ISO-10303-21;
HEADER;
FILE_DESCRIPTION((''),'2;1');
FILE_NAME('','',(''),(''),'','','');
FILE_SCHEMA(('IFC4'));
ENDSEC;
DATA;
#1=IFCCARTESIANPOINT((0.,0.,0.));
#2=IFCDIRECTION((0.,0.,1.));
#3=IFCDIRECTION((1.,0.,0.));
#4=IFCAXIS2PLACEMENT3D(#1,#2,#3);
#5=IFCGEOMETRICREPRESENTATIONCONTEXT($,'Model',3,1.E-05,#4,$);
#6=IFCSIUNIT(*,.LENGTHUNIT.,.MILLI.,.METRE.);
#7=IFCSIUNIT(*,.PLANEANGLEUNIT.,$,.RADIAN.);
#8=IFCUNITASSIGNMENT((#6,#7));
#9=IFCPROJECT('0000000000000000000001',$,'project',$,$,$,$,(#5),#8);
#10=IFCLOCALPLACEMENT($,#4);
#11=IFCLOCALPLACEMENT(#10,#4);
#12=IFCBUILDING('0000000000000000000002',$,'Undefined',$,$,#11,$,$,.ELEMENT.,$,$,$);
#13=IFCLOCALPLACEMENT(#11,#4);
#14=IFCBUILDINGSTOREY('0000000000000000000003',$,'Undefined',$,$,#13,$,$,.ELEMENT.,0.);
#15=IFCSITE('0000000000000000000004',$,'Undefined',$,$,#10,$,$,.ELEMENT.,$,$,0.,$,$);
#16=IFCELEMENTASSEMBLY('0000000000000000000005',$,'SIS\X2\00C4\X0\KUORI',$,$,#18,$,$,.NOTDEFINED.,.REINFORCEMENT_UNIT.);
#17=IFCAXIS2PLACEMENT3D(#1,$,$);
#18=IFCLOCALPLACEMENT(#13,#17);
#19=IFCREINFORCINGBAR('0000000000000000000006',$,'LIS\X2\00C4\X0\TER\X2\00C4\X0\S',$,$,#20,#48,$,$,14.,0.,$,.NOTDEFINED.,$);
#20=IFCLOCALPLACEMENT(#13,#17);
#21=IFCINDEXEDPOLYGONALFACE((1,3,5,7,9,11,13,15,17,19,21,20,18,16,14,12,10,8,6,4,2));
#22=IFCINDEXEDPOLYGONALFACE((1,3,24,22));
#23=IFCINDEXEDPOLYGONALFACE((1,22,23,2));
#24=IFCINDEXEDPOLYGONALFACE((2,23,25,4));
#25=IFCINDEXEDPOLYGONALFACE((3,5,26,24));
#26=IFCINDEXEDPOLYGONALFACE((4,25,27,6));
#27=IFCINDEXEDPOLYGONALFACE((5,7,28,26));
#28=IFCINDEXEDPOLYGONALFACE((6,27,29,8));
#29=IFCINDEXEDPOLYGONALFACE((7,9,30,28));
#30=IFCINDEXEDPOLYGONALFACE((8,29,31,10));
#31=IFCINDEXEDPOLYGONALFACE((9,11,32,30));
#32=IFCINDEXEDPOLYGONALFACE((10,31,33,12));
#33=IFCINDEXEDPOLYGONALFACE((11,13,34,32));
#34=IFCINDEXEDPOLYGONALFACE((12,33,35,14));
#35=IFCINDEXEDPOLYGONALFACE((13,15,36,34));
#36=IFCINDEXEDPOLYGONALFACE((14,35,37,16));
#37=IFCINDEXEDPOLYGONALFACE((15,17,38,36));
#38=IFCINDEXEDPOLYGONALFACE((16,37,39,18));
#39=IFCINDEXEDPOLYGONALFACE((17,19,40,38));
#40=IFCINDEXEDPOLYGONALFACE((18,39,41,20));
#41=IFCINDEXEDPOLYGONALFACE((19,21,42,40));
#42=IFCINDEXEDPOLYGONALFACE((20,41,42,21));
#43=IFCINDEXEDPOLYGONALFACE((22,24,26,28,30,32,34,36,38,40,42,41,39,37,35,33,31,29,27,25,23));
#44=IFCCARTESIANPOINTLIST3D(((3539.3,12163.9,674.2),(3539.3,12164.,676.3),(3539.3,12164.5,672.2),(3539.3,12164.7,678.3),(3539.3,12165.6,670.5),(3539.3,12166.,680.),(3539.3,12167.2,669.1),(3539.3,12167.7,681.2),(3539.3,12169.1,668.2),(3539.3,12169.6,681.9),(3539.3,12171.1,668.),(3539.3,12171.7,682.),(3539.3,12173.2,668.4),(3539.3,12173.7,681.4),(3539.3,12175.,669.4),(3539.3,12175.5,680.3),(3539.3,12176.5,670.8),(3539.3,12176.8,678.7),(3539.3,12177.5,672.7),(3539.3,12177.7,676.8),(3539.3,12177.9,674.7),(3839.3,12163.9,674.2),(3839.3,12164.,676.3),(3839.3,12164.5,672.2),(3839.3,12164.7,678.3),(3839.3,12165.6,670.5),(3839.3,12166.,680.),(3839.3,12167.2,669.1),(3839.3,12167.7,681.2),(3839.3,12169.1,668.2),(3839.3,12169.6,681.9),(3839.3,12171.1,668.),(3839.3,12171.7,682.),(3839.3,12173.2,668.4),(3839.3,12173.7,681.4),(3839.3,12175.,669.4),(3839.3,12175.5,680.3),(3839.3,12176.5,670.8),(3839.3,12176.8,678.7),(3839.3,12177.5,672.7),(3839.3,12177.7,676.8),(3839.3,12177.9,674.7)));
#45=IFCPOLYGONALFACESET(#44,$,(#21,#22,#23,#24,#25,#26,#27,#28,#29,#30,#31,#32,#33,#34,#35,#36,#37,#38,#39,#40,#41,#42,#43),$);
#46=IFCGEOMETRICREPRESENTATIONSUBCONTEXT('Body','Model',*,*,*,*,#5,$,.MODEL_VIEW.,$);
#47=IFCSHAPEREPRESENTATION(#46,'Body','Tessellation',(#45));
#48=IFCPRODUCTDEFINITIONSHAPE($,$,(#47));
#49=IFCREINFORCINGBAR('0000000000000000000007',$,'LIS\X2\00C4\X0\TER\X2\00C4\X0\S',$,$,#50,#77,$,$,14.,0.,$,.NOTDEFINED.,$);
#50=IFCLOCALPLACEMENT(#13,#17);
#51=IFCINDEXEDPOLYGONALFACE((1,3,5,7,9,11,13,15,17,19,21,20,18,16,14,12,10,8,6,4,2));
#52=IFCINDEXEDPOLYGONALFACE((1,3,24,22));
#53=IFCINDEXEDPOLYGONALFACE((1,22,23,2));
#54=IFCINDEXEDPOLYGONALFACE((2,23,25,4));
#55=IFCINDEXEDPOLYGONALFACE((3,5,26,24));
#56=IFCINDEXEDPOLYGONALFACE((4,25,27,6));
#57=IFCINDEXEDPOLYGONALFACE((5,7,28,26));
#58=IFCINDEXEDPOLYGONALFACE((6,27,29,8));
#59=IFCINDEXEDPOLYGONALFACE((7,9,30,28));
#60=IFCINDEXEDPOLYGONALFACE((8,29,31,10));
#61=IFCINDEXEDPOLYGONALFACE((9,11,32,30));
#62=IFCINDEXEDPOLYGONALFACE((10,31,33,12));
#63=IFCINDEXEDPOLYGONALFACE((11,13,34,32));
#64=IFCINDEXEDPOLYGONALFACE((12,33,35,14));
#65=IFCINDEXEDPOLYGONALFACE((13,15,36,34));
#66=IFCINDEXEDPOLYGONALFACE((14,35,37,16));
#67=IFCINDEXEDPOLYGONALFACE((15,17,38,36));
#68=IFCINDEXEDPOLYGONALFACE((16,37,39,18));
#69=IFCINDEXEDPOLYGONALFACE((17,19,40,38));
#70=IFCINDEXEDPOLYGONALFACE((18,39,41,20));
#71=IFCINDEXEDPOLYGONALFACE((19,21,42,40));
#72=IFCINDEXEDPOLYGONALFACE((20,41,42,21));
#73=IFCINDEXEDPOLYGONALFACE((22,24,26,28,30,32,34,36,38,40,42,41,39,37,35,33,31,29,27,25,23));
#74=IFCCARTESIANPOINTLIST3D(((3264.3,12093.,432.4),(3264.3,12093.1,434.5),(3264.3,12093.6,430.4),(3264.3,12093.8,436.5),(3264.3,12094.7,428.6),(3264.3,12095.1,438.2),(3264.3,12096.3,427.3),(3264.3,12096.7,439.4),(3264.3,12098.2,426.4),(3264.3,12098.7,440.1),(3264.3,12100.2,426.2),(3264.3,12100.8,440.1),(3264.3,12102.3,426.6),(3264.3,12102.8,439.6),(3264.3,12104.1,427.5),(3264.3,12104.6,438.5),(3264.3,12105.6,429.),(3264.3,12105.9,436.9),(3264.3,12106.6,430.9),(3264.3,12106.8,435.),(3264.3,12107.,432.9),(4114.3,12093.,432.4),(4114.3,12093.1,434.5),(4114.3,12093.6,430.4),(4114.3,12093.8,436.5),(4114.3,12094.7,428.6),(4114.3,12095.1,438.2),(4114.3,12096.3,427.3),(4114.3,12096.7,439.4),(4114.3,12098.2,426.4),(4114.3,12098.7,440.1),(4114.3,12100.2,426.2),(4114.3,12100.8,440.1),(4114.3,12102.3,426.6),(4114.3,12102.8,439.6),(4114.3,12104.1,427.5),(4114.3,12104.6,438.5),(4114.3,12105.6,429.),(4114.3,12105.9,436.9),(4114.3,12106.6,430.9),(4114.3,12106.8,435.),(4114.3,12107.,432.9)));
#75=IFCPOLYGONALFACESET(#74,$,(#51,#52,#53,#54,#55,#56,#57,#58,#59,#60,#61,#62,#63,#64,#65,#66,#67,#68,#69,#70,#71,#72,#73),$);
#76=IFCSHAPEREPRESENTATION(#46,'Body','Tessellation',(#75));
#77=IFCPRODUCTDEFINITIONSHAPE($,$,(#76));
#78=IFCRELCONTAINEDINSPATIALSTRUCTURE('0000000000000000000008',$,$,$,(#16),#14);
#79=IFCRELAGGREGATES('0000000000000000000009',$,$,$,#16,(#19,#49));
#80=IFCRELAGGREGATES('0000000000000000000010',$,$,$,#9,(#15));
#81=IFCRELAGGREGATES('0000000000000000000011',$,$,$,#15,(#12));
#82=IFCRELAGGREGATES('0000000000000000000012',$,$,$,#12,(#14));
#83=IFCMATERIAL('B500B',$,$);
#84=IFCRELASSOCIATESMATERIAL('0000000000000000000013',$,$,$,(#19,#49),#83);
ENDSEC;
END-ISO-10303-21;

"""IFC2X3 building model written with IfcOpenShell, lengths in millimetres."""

from ifc_helpers import new_model, entity, si_unit, frame, origin_with_axes, place, context, subcontext, project, spatial, source, transform, mapped, material, element, aggregate, save


model = new_model("IFC2X3")

# Units and contexts
model_context = context("Model", 3, precision=1e-05, world=origin_with_axes())
body_context = subcontext(model_context, "Body", "Model", "MODEL_VIEW")
ifc_project = project(units=[si_unit("LENGTHUNIT", "METRE", prefix="MILLI"), si_unit("PLANEANGLEUNIT", "RADIAN")], contexts=[model_context])

# Site, building, storey
site_placement = place(None, origin_with_axes())
site = spatial("IfcSite", under=ifc_project, at=site_placement, Name="Undefined", CompositionType="ELEMENT", RefElevation=0.0)
building_placement = place(site_placement, origin_with_axes())
building = spatial("IfcBuilding", under=site, at=building_placement, Name="Undefined", CompositionType="ELEMENT")
storey_placement = place(building_placement, origin_with_axes())
storey = spatial("IfcBuildingStorey", under=building, at=storey_placement, Name="Undefined", CompositionType="ELEMENT", Elevation=0.0)

# Element assembly
assembly_1_placement = place(storey_placement, origin_with_axes())
assembly_1 = element("IfcElementAssembly", 1, at=assembly_1_placement, inside=storey, Name="SISÄKUORI", AssemblyPlace="NOTDEFINED", PredefinedType="REINFORCEMENT_UNIT")

# Reinforcing bars
ifc_material_1 = material(Name="B500B")
shared_shape_1 = source(origin_with_axes(), body_context, "Body", "AdvancedSweptSolid", [
    entity("IfcSweptDiskSolid", entity("IfcTrimmedCurve", entity("IfcLine", entity("IfcCartesianPoint", [0.0, 0.0, 0.0]), entity("IfcVector", entity("IfcDirection", [1.0, 0.0, 0.0]), 1.0)), [entity("IfcParameterValue", 0.0)], [entity("IfcParameterValue", 300.0)], True, "PARAMETER"), 7.0, None, 0.0, 300.0),
])
reinforcing_bar_1_placement = place(assembly_1_placement, frame((3539.3, 12170.9, 675.0), z_axis=(0.0, 0.034142, -0.999417), x_axis=(1.0, 0.0, 0.0)))
reinforcing_bar_1 = element("IfcReinforcingBar", 2, at=reinforcing_bar_1_placement, material=ifc_material_1, Name="LISÄTERÄS", BarRole="NOTDEFINED", CrossSectionArea=0.0, NominalDiameter=14.0, context=body_context, shape_type="MappedRepresentation", body=[
    mapped(shared_shape_1, transform((0.0, 0.0, 0.0))),
])
shared_shape_2 = source(origin_with_axes(), body_context, "Body", "AdvancedSweptSolid", [
    entity("IfcSweptDiskSolid", entity("IfcTrimmedCurve", entity("IfcLine", entity("IfcCartesianPoint", [0.0, 0.0, 0.0]), entity("IfcVector", entity("IfcDirection", [1.0, 0.0, 0.0]), 1.0)), [entity("IfcParameterValue", 0.0)], [entity("IfcParameterValue", 850.0)], True, "PARAMETER"), 7.0, None, 0.0, 850.0),
])
reinforcing_bar_2_placement = place(assembly_1_placement, frame((3264.3, 12100.0, 433.2), z_axis=(0.0, 0.034142, -0.999417), x_axis=(1.0, 0.0, 0.0)))
reinforcing_bar_2 = element("IfcReinforcingBar", 3, at=reinforcing_bar_2_placement, material=ifc_material_1, Name="LISÄTERÄS", BarRole="NOTDEFINED", CrossSectionArea=0.0, NominalDiameter=14.0, context=body_context, shape_type="MappedRepresentation", body=[
    mapped(shared_shape_2, transform((0.0, 0.0, 0.0))),
])
aggregate(assembly_1, [reinforcing_bar_1, reinforcing_bar_2])

save(model, "model.ifc")
